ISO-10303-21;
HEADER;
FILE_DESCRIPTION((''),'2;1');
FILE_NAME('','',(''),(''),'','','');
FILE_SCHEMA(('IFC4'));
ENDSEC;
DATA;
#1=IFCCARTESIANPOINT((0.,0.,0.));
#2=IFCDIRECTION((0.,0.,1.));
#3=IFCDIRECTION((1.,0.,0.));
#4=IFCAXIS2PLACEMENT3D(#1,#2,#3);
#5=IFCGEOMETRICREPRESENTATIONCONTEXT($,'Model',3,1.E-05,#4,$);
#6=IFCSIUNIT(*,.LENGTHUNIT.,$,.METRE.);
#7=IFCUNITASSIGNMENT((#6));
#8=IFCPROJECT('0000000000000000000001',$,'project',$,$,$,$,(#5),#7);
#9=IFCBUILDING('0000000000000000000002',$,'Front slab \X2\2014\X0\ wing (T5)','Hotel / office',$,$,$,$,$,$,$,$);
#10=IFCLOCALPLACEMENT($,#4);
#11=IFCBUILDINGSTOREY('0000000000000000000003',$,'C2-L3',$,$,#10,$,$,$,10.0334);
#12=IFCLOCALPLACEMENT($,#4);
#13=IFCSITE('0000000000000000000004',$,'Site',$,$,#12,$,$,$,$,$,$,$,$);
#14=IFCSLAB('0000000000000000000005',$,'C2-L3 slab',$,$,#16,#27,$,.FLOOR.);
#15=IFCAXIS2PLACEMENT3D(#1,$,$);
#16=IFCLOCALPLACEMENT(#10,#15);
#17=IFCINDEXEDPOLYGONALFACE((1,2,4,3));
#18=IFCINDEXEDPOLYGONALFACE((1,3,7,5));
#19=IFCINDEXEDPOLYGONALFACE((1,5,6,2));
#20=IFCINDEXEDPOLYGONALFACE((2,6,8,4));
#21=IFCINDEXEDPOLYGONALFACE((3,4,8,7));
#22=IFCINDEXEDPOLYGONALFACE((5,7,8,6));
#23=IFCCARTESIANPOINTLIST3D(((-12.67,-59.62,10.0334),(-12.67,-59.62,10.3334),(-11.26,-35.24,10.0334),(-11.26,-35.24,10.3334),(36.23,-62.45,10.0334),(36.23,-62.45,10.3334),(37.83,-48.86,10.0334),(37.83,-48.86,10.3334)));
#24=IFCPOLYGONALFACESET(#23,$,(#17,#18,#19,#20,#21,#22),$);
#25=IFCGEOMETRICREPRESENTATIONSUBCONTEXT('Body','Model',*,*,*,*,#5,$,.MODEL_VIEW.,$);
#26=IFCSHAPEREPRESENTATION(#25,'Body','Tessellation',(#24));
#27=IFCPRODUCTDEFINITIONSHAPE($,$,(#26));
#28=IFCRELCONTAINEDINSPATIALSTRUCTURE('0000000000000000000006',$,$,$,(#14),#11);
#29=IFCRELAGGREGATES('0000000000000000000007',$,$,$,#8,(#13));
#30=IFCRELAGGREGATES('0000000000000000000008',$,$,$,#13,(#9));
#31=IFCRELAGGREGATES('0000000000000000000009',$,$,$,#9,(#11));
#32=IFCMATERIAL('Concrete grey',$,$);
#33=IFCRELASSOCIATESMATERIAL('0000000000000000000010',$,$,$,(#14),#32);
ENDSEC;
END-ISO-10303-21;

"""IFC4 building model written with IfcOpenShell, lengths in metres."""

from ifc_helpers import new_model, si_unit, frame, origin_with_axes, place, context, subcontext, project, spatial, polyline, outline, extrude, material, element, save


model = new_model("IFC4")

# Units and contexts
model_context = context("Model", 3, precision=1e-05, world=origin_with_axes())
body_context = subcontext(model_context, "Body", "Model", "MODEL_VIEW")
ifc_project = project(units=[si_unit("LENGTHUNIT", "METRE")], contexts=[model_context])

# Site, building, storey
site_placement = place(None, origin_with_axes())
site = spatial("IfcSite", under=ifc_project, at=site_placement, Name="Site")
building = spatial("IfcBuilding", under=site, Name="Front slab — wing (T5)", Description="Hotel / office")
storey_placement = place(None, origin_with_axes())
storey = spatial("IfcBuildingStorey", under=building, at=storey_placement, Name="C2-L3", Elevation=10.0334)

# Slab
ifc_material_1 = material(Name="Concrete grey")
slab_placement = place(storey_placement, origin_with_axes())
element("IfcSlab", 1, at=slab_placement, inside=storey, material=ifc_material_1, Name="C2-L3 slab", PredefinedType="FLOOR", context=body_context, shape_type="SweptSolid", body=[
    extrude(outline(polyline([(-11.26, -35.24), (-12.67, -59.62), (36.23, -62.45), (37.83, -48.86), (-11.26, -35.24)])), frame((0.0, 0.0, 10.0334), z_axis=(0.0, 0.0, 1.0), x_axis=(1.0, 0.0, 0.0)), (0.0, 0.0, 1.0), 0.3),
])

save(model, "model.ifc")
